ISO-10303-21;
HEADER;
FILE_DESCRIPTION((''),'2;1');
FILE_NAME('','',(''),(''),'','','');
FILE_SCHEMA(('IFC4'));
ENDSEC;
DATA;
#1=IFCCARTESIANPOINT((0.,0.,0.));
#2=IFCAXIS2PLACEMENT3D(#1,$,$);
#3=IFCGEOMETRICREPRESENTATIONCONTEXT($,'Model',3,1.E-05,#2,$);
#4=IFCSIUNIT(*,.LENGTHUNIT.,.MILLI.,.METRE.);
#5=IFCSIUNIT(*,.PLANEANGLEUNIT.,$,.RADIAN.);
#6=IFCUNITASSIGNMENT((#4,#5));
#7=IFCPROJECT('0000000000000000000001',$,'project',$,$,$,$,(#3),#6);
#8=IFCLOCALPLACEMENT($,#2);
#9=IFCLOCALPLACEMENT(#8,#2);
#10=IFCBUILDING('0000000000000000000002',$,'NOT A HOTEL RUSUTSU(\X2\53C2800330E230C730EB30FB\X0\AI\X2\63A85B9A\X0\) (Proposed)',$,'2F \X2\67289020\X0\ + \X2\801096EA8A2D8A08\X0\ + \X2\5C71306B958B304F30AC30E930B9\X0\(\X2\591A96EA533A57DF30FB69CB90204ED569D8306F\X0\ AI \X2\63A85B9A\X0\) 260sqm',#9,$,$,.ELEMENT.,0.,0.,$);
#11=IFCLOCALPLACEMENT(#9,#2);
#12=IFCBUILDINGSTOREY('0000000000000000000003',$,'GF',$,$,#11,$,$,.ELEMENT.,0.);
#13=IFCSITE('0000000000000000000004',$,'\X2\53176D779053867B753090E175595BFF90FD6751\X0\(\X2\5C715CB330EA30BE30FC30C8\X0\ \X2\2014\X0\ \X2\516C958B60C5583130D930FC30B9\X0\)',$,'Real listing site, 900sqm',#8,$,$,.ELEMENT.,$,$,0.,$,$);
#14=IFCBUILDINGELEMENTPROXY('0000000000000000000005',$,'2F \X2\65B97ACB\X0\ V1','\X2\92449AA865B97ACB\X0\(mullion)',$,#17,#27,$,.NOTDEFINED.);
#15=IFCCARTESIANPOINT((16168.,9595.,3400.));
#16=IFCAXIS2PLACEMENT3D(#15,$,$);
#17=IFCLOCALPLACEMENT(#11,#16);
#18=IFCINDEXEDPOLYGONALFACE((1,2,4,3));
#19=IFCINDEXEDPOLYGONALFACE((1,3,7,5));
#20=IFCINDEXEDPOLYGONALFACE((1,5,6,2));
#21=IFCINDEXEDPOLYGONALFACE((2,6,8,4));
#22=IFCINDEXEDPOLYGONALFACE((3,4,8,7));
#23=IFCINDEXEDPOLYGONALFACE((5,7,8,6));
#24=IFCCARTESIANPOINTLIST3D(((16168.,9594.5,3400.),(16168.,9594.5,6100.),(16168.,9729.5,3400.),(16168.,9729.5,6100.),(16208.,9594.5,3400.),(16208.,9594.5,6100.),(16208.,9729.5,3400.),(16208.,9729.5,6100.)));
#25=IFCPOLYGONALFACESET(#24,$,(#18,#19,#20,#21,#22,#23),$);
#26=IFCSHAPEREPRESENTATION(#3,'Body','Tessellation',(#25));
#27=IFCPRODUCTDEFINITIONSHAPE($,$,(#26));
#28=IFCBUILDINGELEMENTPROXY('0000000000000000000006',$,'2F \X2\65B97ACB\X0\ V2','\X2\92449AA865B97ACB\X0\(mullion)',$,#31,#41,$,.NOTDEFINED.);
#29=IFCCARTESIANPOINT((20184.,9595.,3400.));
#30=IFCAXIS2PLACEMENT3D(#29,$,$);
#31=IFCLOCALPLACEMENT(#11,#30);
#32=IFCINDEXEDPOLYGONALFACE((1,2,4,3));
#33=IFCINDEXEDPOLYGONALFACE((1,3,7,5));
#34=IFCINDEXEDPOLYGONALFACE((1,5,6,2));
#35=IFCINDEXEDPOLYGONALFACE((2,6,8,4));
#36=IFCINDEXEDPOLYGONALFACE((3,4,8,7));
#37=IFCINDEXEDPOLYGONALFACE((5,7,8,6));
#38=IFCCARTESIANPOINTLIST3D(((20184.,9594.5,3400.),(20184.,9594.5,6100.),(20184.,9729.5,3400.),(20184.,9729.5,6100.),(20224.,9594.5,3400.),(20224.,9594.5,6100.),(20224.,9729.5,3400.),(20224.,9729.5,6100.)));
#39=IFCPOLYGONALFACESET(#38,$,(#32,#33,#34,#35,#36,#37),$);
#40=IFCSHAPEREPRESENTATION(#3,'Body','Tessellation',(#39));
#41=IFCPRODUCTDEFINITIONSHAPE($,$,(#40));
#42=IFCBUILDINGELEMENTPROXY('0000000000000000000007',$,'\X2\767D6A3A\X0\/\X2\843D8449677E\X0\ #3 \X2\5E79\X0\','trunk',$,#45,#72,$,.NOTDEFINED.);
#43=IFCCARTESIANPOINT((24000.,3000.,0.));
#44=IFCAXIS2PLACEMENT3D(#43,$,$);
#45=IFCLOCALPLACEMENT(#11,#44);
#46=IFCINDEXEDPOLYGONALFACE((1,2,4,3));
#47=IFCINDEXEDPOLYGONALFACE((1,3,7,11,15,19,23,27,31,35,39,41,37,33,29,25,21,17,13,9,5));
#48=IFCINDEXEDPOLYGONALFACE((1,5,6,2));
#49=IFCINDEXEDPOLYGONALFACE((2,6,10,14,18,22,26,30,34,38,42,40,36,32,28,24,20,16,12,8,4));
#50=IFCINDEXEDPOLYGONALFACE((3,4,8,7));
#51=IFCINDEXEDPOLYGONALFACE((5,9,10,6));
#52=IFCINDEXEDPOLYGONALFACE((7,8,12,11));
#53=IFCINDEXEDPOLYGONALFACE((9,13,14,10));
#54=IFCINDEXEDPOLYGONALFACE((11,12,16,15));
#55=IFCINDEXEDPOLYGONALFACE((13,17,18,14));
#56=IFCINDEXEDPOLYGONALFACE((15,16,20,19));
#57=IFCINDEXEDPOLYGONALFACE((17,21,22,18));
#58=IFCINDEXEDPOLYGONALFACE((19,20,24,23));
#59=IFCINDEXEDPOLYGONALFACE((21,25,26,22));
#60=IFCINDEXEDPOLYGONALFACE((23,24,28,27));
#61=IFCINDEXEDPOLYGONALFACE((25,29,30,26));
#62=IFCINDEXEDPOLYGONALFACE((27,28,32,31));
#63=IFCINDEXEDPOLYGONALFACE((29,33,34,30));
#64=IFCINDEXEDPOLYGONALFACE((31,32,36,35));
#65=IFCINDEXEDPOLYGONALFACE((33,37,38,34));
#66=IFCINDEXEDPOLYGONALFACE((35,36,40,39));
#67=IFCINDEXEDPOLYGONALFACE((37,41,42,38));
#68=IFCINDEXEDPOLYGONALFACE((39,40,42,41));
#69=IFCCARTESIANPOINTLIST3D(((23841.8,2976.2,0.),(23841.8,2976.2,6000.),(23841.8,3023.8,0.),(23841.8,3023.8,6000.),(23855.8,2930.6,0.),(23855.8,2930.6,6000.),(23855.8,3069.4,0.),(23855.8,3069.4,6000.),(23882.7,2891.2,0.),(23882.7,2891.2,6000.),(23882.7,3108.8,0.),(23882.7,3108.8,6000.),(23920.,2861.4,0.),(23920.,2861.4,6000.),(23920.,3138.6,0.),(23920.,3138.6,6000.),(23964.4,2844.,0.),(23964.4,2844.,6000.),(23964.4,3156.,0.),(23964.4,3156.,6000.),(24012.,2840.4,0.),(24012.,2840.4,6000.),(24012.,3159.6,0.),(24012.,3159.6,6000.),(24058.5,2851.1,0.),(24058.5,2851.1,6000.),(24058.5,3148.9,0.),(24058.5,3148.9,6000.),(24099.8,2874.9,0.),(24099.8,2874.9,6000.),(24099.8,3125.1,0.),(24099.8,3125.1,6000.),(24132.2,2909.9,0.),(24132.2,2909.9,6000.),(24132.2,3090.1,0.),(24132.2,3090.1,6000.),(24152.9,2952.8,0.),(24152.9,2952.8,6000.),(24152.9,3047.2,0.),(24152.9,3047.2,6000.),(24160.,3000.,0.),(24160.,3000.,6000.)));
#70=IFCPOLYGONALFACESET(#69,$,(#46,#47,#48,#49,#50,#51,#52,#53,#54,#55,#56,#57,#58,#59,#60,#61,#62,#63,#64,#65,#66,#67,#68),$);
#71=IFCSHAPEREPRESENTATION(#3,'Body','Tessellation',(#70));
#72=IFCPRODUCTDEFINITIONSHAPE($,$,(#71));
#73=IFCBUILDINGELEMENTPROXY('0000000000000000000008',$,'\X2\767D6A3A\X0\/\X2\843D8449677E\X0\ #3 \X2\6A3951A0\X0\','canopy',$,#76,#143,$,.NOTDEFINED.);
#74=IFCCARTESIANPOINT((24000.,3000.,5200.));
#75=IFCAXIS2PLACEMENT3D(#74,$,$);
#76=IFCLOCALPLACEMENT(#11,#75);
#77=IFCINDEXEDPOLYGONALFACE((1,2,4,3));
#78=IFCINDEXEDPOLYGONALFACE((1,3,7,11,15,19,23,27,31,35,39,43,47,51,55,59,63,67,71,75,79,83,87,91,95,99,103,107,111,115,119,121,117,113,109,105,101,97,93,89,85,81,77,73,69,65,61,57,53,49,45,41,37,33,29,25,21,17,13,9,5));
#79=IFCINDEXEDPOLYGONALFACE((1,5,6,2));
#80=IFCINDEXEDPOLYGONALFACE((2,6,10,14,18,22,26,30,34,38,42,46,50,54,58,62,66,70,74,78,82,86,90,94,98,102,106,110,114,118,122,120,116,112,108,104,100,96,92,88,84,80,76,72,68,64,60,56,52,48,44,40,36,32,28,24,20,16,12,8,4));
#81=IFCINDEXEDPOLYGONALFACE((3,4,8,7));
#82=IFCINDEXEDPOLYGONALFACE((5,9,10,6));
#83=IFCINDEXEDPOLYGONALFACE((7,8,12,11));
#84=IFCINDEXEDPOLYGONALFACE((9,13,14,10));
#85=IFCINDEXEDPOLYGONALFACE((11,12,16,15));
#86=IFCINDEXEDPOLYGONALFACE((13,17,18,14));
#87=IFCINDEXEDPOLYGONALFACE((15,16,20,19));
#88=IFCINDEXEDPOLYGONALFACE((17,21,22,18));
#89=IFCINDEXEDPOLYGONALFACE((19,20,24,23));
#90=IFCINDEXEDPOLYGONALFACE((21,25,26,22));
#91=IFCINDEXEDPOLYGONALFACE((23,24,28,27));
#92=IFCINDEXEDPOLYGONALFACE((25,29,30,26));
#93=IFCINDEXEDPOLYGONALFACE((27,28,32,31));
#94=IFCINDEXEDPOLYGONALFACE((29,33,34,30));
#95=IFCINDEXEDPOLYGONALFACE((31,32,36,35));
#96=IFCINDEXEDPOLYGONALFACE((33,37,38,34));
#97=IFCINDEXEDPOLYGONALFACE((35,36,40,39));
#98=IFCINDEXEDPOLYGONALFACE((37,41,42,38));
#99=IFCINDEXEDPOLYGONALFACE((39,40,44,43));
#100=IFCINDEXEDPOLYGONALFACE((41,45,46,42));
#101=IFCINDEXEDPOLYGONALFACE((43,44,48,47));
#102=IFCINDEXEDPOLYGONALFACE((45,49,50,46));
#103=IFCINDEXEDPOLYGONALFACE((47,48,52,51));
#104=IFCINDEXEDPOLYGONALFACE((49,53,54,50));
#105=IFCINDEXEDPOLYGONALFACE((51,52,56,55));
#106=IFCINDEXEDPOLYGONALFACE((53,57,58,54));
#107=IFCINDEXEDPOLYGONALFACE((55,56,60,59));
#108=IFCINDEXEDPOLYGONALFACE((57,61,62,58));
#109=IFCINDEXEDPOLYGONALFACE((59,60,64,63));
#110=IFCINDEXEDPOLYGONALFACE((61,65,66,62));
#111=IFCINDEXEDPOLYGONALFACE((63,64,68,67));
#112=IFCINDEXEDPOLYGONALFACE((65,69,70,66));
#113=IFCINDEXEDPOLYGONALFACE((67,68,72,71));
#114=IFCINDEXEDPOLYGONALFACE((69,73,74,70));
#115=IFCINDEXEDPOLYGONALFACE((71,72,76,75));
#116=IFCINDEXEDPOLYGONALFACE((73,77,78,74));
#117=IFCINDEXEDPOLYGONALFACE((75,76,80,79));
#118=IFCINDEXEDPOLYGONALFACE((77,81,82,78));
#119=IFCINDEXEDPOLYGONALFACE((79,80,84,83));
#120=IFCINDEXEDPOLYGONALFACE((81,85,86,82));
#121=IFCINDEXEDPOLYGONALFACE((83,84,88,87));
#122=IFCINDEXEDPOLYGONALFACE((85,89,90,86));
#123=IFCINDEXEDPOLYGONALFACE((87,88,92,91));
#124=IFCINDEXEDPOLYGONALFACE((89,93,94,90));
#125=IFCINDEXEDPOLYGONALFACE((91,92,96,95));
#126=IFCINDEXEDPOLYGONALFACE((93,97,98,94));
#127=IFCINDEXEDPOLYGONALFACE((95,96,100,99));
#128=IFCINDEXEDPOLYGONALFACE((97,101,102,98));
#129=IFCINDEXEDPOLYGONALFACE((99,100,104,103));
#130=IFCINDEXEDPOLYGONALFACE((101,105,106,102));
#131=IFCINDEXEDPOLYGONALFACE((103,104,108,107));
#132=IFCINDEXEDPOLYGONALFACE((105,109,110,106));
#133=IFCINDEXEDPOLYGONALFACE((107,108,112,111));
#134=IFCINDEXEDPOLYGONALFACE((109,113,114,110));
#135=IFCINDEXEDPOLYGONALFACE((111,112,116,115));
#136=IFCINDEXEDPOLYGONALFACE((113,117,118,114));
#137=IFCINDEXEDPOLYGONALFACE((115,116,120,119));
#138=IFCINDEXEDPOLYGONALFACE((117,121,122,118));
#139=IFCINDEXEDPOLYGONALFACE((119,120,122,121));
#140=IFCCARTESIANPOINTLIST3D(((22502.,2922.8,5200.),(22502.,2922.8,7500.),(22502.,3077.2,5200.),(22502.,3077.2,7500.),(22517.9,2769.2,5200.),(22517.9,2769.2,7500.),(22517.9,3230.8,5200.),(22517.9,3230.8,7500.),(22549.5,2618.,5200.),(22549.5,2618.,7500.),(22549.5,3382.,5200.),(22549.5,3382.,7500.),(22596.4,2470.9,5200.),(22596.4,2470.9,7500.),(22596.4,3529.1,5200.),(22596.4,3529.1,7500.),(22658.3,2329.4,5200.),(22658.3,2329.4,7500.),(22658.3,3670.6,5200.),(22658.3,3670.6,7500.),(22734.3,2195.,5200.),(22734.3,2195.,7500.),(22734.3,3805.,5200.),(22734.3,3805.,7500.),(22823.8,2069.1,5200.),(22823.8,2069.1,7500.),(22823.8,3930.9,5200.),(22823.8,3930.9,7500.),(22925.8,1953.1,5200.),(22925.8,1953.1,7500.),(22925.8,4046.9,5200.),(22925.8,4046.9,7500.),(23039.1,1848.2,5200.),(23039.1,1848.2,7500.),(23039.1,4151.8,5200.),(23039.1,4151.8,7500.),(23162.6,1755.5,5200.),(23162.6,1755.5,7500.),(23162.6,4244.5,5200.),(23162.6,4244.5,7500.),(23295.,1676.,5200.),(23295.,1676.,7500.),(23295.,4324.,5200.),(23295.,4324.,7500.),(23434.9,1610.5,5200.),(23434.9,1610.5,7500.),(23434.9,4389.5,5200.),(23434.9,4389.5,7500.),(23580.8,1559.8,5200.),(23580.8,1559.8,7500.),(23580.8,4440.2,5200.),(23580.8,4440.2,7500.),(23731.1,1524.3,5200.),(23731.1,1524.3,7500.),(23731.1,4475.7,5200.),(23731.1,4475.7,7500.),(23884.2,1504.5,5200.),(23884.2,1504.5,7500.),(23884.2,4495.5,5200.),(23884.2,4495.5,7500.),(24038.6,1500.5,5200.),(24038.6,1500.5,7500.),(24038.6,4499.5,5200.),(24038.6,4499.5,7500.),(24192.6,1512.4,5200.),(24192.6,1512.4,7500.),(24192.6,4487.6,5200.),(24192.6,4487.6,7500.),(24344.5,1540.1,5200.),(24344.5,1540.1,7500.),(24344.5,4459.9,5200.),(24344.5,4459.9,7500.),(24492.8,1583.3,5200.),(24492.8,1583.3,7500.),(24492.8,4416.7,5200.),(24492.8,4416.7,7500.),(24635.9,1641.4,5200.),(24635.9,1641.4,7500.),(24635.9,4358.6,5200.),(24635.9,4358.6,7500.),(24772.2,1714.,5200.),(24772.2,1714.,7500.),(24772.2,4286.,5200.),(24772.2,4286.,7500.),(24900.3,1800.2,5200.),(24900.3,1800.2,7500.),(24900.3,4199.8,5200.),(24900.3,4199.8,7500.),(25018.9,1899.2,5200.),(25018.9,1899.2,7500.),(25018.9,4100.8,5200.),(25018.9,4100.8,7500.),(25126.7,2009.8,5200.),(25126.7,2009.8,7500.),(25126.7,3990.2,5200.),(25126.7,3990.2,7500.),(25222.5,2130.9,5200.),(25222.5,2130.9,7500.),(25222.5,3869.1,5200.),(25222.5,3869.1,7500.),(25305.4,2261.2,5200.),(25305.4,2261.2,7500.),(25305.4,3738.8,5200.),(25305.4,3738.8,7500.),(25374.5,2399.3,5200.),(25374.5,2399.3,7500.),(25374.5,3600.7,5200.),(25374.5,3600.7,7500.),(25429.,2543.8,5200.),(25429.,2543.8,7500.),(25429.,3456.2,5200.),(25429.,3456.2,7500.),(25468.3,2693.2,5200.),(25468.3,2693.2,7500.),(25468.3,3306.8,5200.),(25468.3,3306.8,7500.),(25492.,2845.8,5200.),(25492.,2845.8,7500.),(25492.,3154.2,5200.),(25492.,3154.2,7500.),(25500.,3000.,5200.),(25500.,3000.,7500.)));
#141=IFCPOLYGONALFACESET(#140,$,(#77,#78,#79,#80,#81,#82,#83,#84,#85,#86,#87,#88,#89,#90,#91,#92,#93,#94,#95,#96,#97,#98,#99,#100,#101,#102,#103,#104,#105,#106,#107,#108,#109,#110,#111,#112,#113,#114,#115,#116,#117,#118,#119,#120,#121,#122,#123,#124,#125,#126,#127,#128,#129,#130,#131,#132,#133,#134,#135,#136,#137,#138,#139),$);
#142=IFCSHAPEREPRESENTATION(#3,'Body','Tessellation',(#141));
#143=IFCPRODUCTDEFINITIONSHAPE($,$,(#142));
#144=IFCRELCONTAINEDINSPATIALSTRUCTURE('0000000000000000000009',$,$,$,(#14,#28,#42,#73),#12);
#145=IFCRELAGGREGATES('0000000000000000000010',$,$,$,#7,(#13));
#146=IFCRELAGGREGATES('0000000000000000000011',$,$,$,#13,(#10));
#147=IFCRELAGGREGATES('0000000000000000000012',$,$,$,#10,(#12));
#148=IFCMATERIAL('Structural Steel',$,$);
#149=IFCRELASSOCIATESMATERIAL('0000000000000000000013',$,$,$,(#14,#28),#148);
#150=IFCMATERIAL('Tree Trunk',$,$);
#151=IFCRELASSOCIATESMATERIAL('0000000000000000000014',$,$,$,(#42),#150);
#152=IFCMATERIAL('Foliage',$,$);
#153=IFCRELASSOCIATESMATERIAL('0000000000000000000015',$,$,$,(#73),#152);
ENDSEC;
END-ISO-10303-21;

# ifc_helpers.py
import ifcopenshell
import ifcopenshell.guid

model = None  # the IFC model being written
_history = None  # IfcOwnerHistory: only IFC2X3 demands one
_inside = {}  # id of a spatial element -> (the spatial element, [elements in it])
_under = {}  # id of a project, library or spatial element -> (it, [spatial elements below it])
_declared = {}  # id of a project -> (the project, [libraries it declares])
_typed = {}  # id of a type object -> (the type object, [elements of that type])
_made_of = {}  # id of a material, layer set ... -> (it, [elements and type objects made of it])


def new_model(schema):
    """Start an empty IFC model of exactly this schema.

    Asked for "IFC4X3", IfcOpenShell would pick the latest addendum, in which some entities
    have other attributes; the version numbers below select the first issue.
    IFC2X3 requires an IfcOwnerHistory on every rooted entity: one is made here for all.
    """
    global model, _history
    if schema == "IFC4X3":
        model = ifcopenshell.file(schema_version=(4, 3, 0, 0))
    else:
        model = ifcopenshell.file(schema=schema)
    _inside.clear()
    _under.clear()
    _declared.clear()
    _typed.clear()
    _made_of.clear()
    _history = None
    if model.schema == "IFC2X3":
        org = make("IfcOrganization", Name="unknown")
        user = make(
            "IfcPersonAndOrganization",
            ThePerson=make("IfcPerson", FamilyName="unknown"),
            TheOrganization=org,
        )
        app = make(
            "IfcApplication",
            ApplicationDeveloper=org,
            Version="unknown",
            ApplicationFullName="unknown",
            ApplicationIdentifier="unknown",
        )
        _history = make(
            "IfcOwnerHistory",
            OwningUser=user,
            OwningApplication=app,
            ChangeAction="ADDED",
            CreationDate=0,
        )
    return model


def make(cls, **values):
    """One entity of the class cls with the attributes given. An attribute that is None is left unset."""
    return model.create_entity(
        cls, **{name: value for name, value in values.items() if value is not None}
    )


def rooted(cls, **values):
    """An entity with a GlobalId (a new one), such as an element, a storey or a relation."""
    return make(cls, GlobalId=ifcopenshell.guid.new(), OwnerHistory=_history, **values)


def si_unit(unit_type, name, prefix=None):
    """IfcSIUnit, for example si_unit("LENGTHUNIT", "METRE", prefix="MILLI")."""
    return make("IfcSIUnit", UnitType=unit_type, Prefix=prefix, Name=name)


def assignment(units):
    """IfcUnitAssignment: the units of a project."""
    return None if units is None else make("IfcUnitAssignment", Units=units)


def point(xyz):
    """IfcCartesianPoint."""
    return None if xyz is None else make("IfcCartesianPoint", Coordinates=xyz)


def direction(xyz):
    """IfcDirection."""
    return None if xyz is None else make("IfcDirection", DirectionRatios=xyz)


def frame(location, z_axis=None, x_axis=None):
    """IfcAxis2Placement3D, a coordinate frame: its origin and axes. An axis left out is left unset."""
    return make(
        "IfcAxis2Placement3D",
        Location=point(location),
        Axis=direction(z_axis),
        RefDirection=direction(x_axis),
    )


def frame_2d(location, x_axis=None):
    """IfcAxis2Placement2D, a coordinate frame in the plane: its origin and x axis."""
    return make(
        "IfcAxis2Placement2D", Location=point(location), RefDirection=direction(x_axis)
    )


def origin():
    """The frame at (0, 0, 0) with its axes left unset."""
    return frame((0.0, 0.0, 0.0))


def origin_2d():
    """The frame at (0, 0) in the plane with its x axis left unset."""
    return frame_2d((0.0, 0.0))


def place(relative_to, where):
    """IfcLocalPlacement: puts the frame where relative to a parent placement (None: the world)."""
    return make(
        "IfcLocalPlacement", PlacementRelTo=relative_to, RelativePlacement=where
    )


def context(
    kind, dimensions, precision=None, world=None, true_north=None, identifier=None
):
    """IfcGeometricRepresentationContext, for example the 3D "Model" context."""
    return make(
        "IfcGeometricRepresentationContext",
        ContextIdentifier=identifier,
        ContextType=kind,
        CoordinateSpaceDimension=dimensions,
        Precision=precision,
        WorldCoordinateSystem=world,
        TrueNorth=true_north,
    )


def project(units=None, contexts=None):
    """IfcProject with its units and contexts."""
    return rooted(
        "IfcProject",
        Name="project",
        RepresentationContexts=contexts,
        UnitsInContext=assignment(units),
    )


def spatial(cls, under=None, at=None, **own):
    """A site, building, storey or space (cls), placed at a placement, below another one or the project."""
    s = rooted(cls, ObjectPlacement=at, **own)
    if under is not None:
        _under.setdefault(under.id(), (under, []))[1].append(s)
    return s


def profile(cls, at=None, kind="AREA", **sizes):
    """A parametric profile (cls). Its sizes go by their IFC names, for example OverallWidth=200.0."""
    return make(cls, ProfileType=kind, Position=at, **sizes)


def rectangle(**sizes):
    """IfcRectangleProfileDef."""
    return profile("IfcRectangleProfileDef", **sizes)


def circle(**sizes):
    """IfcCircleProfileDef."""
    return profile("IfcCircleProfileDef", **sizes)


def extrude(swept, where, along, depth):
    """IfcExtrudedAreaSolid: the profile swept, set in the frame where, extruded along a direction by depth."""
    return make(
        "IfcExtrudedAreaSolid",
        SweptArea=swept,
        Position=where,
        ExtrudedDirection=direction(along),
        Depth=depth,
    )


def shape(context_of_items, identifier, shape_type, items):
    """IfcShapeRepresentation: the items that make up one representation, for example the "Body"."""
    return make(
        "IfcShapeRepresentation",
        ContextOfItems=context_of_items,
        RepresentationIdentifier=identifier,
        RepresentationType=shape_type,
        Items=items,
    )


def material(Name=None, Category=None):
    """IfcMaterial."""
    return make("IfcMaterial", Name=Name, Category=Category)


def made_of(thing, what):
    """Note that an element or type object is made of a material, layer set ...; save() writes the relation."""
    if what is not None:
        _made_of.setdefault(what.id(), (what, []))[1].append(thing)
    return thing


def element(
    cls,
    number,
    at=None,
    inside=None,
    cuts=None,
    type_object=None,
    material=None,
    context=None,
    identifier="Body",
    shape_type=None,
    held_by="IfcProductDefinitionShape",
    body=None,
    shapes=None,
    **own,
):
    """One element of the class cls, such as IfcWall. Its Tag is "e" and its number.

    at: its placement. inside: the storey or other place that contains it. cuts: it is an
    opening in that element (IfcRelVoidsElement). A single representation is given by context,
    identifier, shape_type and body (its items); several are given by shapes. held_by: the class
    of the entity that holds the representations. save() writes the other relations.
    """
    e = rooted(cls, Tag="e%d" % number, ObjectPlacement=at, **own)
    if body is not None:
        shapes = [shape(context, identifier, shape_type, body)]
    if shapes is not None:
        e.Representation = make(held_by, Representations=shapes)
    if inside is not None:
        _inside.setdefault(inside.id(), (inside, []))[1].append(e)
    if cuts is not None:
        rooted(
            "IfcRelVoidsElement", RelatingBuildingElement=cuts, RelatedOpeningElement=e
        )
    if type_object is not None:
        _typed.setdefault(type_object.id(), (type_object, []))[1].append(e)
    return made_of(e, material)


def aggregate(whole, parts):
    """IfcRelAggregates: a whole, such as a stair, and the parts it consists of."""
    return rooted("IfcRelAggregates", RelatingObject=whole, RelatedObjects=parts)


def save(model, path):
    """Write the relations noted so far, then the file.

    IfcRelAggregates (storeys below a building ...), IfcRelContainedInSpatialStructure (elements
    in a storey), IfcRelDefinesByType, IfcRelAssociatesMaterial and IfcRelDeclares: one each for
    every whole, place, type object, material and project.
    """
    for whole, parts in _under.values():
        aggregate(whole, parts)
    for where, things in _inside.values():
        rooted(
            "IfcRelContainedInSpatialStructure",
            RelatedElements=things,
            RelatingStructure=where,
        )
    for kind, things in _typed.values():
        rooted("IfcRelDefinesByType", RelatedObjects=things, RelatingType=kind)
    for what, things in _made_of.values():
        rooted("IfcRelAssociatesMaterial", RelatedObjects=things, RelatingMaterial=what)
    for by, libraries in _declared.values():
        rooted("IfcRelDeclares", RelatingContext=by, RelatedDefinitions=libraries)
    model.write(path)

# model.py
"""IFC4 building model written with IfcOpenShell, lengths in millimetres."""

from ifc_helpers import new_model, si_unit, frame, frame_2d, origin, origin_2d, place, context, project, spatial, rectangle, circle, extrude, material, element, save


model = new_model("IFC4")

# Units and contexts
model_context = context("Model", 3, precision=1e-05, world=origin())
ifc_project = project(units=[si_unit("LENGTHUNIT", "METRE", prefix="MILLI"), si_unit("PLANEANGLEUNIT", "RADIAN")], contexts=[model_context])

# Site, building, storey
site_placement = place(None, origin())
site = spatial("IfcSite", under=ifc_project, at=site_placement, Name="北海道虻田郡留寿都村(山岳リゾート — 公開情報ベース)", ObjectType="Real listing site, 900sqm", CompositionType="ELEMENT", RefElevation=0.0)
building_placement = place(site_placement, origin())
building = spatial("IfcBuilding", under=site, at=building_placement, Name="NOT A HOTEL RUSUTSU(参考モデル・AI推定) (Proposed)", ObjectType="2F 木造 + 耐雪設計 + 山に開くガラス(多雪区域・構造仕様は AI 推定) 260sqm", CompositionType="ELEMENT", ElevationOfRefHeight=0.0, ElevationOfTerrain=0.0)
storey_placement = place(building_placement, origin())
storey = spatial("IfcBuildingStorey", under=building, at=storey_placement, Name="GF", CompositionType="ELEMENT", Elevation=0.0)

# Building element proxies
ifc_material_1 = material(Name="Structural Steel")
proxy_1_placement = place(storey_placement, frame((16168.0, 9595.0, 3400.0)))
element("IfcBuildingElementProxy", 1, at=proxy_1_placement, inside=storey, material=ifc_material_1, Name="2F 方立 V1", Description="鉄骨方立(mullion)", PredefinedType="NOTDEFINED", context=model_context, shape_type="SweptSolid", body=[
    extrude(rectangle(XDim=40.0, YDim=135.0, at=frame_2d((20.0, 67.0))), frame((16168.0, 9595.0, 3400.0)), (0.0, 0.0, 1.0), 2700.0),
])
proxy_2_placement = place(storey_placement, frame((20184.0, 9595.0, 3400.0)))
element("IfcBuildingElementProxy", 2, at=proxy_2_placement, inside=storey, material=ifc_material_1, Name="2F 方立 V2", Description="鉄骨方立(mullion)", PredefinedType="NOTDEFINED", context=model_context, shape_type="SweptSolid", body=[
    extrude(rectangle(XDim=40.0, YDim=135.0, at=frame_2d((20.0, 67.0))), frame((20184.0, 9595.0, 3400.0)), (0.0, 0.0, 1.0), 2700.0),
])
ifc_material_2 = material(Name="Tree Trunk")
proxy_3_placement = place(storey_placement, frame((24000.0, 3000.0, 0.0)))
element("IfcBuildingElementProxy", 3, at=proxy_3_placement, inside=storey, material=ifc_material_2, Name="白樺/落葉松 #3 幹", Description="trunk", PredefinedType="NOTDEFINED", context=model_context, shape_type="SweptSolid", body=[
    extrude(circle(Radius=160.0, at=origin_2d()), frame((24000.0, 3000.0, 0.0)), (0.0, 0.0, 1.0), 6000.0),
])
ifc_material_3 = material(Name="Foliage")
proxy_4_placement = place(storey_placement, frame((24000.0, 3000.0, 5200.0)))
element("IfcBuildingElementProxy", 4, at=proxy_4_placement, inside=storey, material=ifc_material_3, Name="白樺/落葉松 #3 樹冠", Description="canopy", PredefinedType="NOTDEFINED", context=model_context, shape_type="SweptSolid", body=[
    extrude(circle(Radius=1500.0, at=origin_2d()), frame((24000.0, 3000.0, 5200.0)), (0.0, 0.0, 1.0), 2300.0),
])

save(model, "model.ifc")
